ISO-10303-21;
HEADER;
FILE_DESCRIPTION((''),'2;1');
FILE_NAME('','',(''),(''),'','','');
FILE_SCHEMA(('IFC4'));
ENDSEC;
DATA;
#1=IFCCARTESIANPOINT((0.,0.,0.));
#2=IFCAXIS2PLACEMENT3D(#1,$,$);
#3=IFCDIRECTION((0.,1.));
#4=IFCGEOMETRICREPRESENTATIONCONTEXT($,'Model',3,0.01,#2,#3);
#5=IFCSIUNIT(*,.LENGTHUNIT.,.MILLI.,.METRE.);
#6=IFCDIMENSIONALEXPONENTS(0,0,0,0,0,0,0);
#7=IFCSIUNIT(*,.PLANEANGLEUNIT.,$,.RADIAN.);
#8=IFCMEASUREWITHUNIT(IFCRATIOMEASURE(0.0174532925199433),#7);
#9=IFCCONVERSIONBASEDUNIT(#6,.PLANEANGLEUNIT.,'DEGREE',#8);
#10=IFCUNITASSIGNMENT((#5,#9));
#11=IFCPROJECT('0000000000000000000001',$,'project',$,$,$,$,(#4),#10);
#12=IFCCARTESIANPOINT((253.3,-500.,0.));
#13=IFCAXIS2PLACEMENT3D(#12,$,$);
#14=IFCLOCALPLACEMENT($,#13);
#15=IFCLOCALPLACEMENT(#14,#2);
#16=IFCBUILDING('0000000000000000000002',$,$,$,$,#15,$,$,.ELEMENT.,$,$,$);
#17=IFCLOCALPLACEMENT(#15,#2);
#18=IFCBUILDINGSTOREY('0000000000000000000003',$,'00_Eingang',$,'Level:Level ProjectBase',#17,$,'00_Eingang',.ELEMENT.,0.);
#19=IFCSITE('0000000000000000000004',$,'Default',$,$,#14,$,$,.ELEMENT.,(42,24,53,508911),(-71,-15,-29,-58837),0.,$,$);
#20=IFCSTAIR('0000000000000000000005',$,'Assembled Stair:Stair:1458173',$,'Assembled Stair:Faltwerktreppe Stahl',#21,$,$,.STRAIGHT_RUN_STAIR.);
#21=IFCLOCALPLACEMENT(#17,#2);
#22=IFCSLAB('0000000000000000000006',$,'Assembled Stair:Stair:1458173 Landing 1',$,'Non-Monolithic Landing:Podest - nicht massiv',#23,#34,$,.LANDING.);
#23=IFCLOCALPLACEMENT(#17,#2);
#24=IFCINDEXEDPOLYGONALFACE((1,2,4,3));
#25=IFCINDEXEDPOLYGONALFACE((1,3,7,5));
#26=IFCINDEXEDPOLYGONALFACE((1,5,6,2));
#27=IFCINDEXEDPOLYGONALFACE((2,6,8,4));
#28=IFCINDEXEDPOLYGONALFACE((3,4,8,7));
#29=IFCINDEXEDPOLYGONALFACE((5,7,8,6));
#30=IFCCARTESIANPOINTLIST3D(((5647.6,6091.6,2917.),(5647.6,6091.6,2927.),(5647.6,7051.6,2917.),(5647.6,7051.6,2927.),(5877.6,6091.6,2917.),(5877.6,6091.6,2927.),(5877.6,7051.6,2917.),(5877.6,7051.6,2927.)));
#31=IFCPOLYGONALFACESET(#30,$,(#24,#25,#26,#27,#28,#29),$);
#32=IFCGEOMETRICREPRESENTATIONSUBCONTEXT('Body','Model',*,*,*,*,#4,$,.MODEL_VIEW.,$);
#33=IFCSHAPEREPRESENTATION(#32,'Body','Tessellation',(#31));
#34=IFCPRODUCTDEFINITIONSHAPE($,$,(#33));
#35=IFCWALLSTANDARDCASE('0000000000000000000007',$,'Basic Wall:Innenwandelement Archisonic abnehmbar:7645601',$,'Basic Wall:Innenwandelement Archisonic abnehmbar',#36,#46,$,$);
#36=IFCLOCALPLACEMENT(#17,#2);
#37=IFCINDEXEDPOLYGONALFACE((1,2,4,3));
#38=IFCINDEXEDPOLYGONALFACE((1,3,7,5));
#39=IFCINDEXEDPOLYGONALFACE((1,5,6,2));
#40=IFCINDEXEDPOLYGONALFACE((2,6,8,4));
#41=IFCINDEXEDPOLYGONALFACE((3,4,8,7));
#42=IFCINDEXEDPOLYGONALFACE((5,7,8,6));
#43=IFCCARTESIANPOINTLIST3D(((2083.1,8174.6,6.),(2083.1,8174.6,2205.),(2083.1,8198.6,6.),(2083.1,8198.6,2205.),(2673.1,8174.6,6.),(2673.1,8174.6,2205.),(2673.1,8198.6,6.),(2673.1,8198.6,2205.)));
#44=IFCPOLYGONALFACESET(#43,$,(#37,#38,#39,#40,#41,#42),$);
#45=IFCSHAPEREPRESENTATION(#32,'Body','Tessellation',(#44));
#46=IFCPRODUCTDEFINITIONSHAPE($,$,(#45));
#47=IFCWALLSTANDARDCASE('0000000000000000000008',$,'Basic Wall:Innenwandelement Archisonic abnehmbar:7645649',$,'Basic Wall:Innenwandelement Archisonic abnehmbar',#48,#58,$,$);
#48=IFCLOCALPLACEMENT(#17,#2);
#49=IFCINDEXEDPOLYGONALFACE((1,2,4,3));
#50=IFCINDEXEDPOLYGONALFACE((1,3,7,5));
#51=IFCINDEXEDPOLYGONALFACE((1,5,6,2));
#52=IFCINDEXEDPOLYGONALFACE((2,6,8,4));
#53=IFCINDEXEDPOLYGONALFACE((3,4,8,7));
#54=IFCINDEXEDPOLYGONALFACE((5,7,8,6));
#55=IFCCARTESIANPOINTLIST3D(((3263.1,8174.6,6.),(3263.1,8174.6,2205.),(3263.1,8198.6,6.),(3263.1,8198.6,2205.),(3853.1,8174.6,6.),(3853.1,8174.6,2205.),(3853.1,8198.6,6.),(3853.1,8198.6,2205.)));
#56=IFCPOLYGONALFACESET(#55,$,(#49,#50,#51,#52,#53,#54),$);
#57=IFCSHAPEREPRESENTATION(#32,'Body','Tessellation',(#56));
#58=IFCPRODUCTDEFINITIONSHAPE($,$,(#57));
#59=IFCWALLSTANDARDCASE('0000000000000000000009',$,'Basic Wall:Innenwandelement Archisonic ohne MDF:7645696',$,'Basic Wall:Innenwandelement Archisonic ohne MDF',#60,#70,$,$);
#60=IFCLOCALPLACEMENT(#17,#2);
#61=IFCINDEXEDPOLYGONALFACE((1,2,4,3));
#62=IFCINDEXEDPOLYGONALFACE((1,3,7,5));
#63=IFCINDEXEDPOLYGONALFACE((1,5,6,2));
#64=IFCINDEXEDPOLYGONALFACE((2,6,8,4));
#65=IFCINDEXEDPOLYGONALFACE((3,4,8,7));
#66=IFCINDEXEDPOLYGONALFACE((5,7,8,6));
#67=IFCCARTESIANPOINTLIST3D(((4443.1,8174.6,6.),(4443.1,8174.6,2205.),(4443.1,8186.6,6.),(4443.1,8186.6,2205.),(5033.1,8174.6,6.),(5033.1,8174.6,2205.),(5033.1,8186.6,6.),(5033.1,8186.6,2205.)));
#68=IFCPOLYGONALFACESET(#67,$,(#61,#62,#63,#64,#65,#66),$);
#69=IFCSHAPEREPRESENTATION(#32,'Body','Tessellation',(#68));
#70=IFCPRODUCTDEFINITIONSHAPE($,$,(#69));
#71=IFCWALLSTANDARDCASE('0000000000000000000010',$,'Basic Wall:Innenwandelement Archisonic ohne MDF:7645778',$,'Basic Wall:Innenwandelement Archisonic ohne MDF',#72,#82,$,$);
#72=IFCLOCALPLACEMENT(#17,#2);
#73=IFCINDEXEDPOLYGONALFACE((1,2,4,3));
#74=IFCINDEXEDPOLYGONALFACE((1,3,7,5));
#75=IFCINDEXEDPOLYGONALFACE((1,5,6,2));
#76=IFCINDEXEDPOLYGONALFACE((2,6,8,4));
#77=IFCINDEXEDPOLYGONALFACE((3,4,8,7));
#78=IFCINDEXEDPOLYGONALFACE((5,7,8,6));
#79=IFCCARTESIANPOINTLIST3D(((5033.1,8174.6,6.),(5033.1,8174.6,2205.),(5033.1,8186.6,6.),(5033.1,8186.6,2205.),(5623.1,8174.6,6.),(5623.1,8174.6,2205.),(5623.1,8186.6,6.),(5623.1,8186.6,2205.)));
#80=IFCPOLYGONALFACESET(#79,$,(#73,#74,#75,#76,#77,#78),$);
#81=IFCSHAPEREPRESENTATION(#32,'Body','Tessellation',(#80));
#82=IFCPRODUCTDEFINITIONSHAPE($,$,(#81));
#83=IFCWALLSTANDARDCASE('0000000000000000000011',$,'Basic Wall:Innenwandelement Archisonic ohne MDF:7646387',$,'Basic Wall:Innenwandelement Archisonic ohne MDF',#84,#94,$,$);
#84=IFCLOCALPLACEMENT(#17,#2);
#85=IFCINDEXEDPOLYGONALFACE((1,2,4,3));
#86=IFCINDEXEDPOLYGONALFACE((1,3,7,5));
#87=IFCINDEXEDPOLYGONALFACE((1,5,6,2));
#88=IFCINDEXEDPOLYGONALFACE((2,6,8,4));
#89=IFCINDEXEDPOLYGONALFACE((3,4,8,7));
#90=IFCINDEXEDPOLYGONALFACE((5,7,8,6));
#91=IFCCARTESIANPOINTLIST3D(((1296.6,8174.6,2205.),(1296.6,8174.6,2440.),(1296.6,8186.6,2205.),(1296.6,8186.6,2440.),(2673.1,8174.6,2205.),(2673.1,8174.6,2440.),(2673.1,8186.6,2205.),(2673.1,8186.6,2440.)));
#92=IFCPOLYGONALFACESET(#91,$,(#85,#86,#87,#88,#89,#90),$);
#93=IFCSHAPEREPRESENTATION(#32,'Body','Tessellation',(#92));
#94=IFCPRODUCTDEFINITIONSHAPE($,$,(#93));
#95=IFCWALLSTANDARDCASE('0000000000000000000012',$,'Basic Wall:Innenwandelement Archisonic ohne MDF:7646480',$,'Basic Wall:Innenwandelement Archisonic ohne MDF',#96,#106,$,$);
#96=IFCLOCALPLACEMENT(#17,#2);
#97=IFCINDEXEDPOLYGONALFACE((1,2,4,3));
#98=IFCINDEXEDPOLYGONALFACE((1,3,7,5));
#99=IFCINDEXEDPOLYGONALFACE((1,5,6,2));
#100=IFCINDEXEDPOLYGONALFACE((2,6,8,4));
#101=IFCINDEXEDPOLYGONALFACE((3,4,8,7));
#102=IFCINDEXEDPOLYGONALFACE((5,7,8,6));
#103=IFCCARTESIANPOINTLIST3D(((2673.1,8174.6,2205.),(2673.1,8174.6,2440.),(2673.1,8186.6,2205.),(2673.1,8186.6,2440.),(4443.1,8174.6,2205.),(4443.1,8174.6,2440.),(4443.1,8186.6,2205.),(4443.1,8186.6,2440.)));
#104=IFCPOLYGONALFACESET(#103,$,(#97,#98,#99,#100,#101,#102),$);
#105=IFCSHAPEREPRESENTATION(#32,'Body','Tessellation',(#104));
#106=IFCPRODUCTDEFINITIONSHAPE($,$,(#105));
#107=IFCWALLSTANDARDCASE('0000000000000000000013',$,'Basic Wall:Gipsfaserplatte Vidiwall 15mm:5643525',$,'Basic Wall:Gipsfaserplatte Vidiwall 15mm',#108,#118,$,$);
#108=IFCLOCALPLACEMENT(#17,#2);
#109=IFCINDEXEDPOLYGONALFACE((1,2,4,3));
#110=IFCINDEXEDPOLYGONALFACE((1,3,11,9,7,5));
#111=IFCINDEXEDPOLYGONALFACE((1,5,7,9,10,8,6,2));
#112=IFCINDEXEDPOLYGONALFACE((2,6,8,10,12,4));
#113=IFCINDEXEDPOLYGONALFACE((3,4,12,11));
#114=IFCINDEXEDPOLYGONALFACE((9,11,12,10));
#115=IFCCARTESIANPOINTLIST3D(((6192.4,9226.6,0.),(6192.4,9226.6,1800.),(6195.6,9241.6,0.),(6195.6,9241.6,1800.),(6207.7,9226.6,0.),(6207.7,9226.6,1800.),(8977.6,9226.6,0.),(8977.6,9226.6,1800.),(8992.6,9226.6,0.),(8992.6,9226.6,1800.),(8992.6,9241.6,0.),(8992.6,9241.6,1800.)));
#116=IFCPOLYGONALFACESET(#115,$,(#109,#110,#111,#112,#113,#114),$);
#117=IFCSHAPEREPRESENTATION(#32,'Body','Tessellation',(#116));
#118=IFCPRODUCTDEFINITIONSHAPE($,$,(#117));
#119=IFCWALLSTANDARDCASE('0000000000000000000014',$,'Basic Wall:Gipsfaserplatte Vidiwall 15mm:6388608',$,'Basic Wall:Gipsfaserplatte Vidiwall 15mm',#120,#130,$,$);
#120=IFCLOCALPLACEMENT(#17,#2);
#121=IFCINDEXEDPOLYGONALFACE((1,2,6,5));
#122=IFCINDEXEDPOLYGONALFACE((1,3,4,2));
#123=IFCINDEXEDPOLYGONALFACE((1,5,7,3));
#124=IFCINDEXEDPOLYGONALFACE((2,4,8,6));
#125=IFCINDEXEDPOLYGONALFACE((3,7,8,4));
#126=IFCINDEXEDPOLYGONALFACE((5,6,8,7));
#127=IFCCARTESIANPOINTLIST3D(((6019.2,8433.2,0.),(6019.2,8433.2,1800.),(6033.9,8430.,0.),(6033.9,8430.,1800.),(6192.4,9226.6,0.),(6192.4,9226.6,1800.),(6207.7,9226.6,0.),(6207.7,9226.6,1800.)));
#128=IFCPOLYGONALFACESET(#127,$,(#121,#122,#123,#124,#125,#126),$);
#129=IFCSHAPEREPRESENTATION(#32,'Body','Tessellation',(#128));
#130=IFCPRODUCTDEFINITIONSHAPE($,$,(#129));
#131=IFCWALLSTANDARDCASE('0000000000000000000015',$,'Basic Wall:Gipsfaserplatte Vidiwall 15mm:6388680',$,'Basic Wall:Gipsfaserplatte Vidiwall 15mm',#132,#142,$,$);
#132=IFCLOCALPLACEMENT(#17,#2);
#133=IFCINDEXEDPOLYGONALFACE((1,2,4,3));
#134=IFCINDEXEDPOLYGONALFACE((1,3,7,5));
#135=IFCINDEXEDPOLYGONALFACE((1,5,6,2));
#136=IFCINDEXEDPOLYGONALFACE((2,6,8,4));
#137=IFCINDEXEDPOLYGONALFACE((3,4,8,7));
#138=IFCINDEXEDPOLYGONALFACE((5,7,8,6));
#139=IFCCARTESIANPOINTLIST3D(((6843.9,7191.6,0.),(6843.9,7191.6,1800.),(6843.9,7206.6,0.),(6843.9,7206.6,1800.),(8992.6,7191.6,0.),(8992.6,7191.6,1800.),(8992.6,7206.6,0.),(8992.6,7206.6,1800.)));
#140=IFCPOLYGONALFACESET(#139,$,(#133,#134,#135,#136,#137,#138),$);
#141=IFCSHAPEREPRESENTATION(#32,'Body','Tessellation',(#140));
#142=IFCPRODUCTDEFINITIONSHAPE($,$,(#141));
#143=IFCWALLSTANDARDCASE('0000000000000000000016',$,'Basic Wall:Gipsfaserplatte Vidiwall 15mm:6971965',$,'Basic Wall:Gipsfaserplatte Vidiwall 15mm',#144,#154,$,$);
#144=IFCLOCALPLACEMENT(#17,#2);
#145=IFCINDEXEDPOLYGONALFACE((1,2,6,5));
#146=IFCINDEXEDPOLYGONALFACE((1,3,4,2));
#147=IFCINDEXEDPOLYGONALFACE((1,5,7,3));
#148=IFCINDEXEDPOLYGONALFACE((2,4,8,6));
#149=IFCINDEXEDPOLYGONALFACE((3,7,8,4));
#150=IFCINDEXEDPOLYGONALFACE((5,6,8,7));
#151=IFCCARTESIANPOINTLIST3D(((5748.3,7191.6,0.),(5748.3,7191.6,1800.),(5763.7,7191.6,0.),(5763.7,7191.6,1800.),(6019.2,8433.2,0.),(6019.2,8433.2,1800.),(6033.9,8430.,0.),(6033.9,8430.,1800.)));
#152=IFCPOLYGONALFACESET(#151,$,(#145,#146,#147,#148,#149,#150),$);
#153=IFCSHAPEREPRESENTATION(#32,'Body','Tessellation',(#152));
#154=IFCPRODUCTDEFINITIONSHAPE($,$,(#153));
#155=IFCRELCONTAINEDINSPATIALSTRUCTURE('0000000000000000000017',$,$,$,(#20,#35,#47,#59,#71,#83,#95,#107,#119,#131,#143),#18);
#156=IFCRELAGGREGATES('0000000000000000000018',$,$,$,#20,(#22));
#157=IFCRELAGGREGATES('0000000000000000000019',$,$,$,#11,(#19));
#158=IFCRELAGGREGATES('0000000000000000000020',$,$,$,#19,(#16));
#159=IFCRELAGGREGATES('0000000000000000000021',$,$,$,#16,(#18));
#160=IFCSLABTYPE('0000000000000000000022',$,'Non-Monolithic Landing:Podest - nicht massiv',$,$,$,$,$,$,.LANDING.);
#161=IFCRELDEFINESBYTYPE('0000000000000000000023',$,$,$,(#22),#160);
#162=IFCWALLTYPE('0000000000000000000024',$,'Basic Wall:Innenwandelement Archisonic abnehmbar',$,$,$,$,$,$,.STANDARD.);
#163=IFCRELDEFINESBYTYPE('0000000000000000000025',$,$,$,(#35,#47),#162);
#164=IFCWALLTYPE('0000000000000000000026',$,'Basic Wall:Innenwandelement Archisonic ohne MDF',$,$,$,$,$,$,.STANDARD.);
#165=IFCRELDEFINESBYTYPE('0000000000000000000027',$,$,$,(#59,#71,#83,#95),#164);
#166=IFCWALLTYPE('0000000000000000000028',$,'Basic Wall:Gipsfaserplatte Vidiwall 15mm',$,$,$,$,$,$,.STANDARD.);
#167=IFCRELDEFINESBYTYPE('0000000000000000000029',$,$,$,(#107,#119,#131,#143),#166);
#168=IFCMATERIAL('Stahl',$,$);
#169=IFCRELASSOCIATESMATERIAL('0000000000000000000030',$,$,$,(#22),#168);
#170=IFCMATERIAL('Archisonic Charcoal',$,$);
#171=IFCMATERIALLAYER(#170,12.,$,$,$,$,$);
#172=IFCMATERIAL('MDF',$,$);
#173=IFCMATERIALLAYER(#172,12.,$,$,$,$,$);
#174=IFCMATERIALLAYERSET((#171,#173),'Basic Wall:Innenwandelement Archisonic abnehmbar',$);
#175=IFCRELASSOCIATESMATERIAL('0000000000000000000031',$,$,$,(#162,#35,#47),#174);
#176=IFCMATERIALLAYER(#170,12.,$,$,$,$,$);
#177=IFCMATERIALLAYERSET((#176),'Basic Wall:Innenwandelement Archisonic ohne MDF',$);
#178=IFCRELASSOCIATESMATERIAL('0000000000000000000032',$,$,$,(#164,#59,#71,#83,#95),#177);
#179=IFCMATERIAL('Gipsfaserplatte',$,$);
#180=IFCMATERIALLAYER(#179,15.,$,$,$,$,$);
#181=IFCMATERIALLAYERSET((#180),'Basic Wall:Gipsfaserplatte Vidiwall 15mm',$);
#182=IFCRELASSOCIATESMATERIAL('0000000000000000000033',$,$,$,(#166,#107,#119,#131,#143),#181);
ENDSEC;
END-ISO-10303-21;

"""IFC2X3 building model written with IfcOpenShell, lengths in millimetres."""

from ifc_helpers import new_model, entity, si_unit, converted_unit, direction, frame, frame_2d, origin, place, context, subcontext, project, spatial, polyline, rectangle, outline, extrude, clip, bounded_halfspace, material, layer, layer_set, layer_usage, type_object, element, aggregate, save


model = new_model("IFC2X3")

# Units and contexts
model_context = context("Model", 3, precision=0.01, world=origin(), true_north=direction((0.0, 1.0)))
body_context = subcontext(model_context, "Body", "Model", "MODEL_VIEW")
ifc_project = project(units=[si_unit("LENGTHUNIT", "METRE", prefix="MILLI"), converted_unit("PLANEANGLEUNIT", "DEGREE", entity("IfcRatioMeasure", 0.0174532925199433), si_unit("PLANEANGLEUNIT", "RADIAN"), dimensions=[0, 0, 0, 0, 0, 0, 0])], contexts=[model_context])

# Site, building, storey
site_placement = place(None, frame((253.3, -500.0, 0.0)))
site = spatial("IfcSite", under=ifc_project, at=site_placement, Name="Default", CompositionType="ELEMENT", RefLatitude=(42, 24, 53, 508911), RefLongitude=(-71, -15, -29, -58837), RefElevation=0.0)
building_placement = place(site_placement, origin())
building = spatial("IfcBuilding", under=site, at=building_placement, CompositionType="ELEMENT")
storey_placement = place(building_placement, origin())
storey = spatial("IfcBuildingStorey", under=building, at=storey_placement, Name="00_Eingang", ObjectType="Level:Level ProjectBase", LongName="00_Eingang", CompositionType="ELEMENT", Elevation=0.0)

# Stair, slab
stair_placement = place(storey_placement, origin())
stair = element("IfcStair", 1, at=stair_placement, inside=storey, Name="Assembled Stair:Stair:1458173", ObjectType="Assembled Stair:Faltwerktreppe Stahl", ShapeType="STRAIGHT_RUN_STAIR")
ifc_material_1 = material(Name="Stahl")
slab_type = type_object("IfcSlabType", Name="Non-Monolithic Landing:Podest - nicht massiv", PredefinedType="LANDING")
slab_placement = place(stair_placement, frame((5647.6, 6091.6, 0.0)))
slab = element("IfcSlab", 2, at=slab_placement, type_object=slab_type, material=ifc_material_1, Name="Assembled Stair:Stair:1458173 Landing 1", ObjectType="Non-Monolithic Landing:Podest - nicht massiv", PredefinedType="LANDING", context=body_context, shape_type="SweptSolid", body=[
    extrude(rectangle(XDim=960.0, YDim=230.0, at=frame_2d((0.0, 0.0), x_axis=(1.0, 0.0))), frame((115.0, 480.0, 2917.0), z_axis=(0.0, 0.0, 1.0), x_axis=(0.0, 1.0, 0.0)), (0.0, 0.0, 1.0), 10.0),
])

# Walls
ifc_material_2 = material(Name="Archisonic Charcoal")
ifc_layer_1 = layer(ifc_material_2, 12.0)
ifc_material_3 = material(Name="MDF")
ifc_layer_2 = layer(ifc_material_3, 12.0)
ifc_layer_set_1 = layer_set([ifc_layer_1, ifc_layer_2], Name="Basic Wall:Innenwandelement Archisonic abnehmbar")
ifc_layer_usage_1 = layer_usage(ifc_layer_set_1, "AXIS2", "NEGATIVE", 12.0)
wall_type_1 = type_object("IfcWallType", Name="Basic Wall:Innenwandelement Archisonic abnehmbar", PredefinedType="STANDARD", material=ifc_layer_set_1)
wall_1_placement = place(storey_placement, frame((2673.1, 8186.6, 6.0), z_axis=(0.0, 0.0, 1.0), x_axis=(-1.0, 0.0, 0.0)))
element("IfcWallStandardCase", 3, at=wall_1_placement, inside=storey, type_object=wall_type_1, material=ifc_layer_usage_1, Name="Basic Wall:Innenwandelement Archisonic abnehmbar:7645601", ObjectType="Basic Wall:Innenwandelement Archisonic abnehmbar", context=body_context, shape_type="SweptSolid", body=[
    extrude(rectangle(XDim=590.0, YDim=24.0, at=frame_2d((295.0, 0.0), x_axis=(-1.0, 0.0))), origin(), (0.0, 0.0, 1.0), 2199.0),
])
ifc_layer_usage_2 = layer_usage(ifc_layer_set_1, "AXIS2", "NEGATIVE", 12.0)
wall_2_placement = place(storey_placement, frame((3853.1, 8186.6, 6.0), z_axis=(0.0, 0.0, 1.0), x_axis=(-1.0, 0.0, 0.0)))
element("IfcWallStandardCase", 4, at=wall_2_placement, inside=storey, type_object=wall_type_1, material=ifc_layer_usage_2, Name="Basic Wall:Innenwandelement Archisonic abnehmbar:7645649", ObjectType="Basic Wall:Innenwandelement Archisonic abnehmbar", context=body_context, shape_type="SweptSolid", body=[
    extrude(rectangle(XDim=590.0, YDim=24.0, at=frame_2d((295.0, 0.0), x_axis=(-1.0, 0.0))), origin(), (0.0, 0.0, 1.0), 2199.0),
])

# Walls
ifc_layer_3 = layer(ifc_material_2, 12.0)
ifc_layer_set_2 = layer_set([ifc_layer_3], Name="Basic Wall:Innenwandelement Archisonic ohne MDF")
ifc_layer_usage_3 = layer_usage(ifc_layer_set_2, "AXIS2", "NEGATIVE", 6.0)
wall_type_2 = type_object("IfcWallType", Name="Basic Wall:Innenwandelement Archisonic ohne MDF", PredefinedType="STANDARD", material=ifc_layer_set_2)
wall_3_placement = place(storey_placement, frame((5033.1, 8180.6, 6.0), z_axis=(0.0, 0.0, 1.0), x_axis=(-1.0, 0.0, 0.0)))
element("IfcWallStandardCase", 5, at=wall_3_placement, inside=storey, type_object=wall_type_2, material=ifc_layer_usage_3, Name="Basic Wall:Innenwandelement Archisonic ohne MDF:7645696", ObjectType="Basic Wall:Innenwandelement Archisonic ohne MDF", context=body_context, shape_type="SweptSolid", body=[
    extrude(rectangle(XDim=590.0, YDim=12.0, at=frame_2d((295.0, 0.0), x_axis=(-1.0, 0.0))), origin(), (0.0, 0.0, 1.0), 2199.0),
])
ifc_layer_usage_4 = layer_usage(ifc_layer_set_2, "AXIS2", "NEGATIVE", 6.0)
wall_4_placement = place(storey_placement, frame((5623.1, 8180.6, 6.0), z_axis=(0.0, 0.0, 1.0), x_axis=(-1.0, 0.0, 0.0)))
element("IfcWallStandardCase", 6, at=wall_4_placement, inside=storey, type_object=wall_type_2, material=ifc_layer_usage_4, Name="Basic Wall:Innenwandelement Archisonic ohne MDF:7645778", ObjectType="Basic Wall:Innenwandelement Archisonic ohne MDF", context=body_context, shape_type="SweptSolid", body=[
    extrude(rectangle(XDim=590.0, YDim=12.0, at=frame_2d((295.0, 0.0), x_axis=(-1.0, 0.0))), origin(), (0.0, 0.0, 1.0), 2199.0),
])
ifc_layer_usage_5 = layer_usage(ifc_layer_set_2, "AXIS2", "NEGATIVE", 6.0)
wall_5_placement = place(storey_placement, frame((2673.1, 8180.6, 2205.0), z_axis=(0.0, 0.0, 1.0), x_axis=(-1.0, 0.0, 0.0)))
element("IfcWallStandardCase", 7, at=wall_5_placement, inside=storey, type_object=wall_type_2, material=ifc_layer_usage_5, Name="Basic Wall:Innenwandelement Archisonic ohne MDF:7646387", ObjectType="Basic Wall:Innenwandelement Archisonic ohne MDF", context=body_context, shape_type="SweptSolid", body=[
    extrude(rectangle(XDim=1376.4, YDim=12.0, at=frame_2d((688.2, 0.0), x_axis=(-1.0, 0.0))), origin(), (0.0, 0.0, 1.0), 235.0),
])
ifc_layer_usage_6 = layer_usage(ifc_layer_set_2, "AXIS2", "POSITIVE", -6.0)
wall_6_placement = place(storey_placement, frame((2673.1, 8180.6, 2205.0)))
element("IfcWallStandardCase", 8, at=wall_6_placement, inside=storey, type_object=wall_type_2, material=ifc_layer_usage_6, Name="Basic Wall:Innenwandelement Archisonic ohne MDF:7646480", ObjectType="Basic Wall:Innenwandelement Archisonic ohne MDF", context=body_context, shape_type="SweptSolid", body=[
    extrude(rectangle(XDim=1770.0, YDim=12.0, at=frame_2d((885.0, 0.0), x_axis=(-1.0, 0.0))), origin(), (0.0, 0.0, 1.0), 235.0),
])
ifc_material_4 = material(Name="Gipsfaserplatte")
ifc_layer_4 = layer(ifc_material_4, 15.0)
ifc_layer_set_3 = layer_set([ifc_layer_4], Name="Basic Wall:Gipsfaserplatte Vidiwall 15mm")
ifc_layer_usage_7 = layer_usage(ifc_layer_set_3, "AXIS2", "NEGATIVE", 7.5)
wall_type_3 = type_object("IfcWallType", Name="Basic Wall:Gipsfaserplatte Vidiwall 15mm", PredefinedType="STANDARD", material=ifc_layer_set_3)
wall_7_placement = place(storey_placement, frame((6192.4, 9234.1, 0.0)))
element("IfcWallStandardCase", 9, at=wall_7_placement, inside=storey, type_object=wall_type_3, material=ifc_layer_usage_7, Name="Basic Wall:Gipsfaserplatte Vidiwall 15mm:5643525", ObjectType="Basic Wall:Gipsfaserplatte Vidiwall 15mm", context=body_context, shape_type="SweptSolid", body=[
    extrude(outline(polyline([(2800.3, -7.5), (2800.3, 7.5), (3.3, 7.5), (0.0, -7.5), (15.4, -7.5), (2785.3, -7.5), (2800.3, -7.5)])), origin(), (0.0, 0.0, 1.0), 1800.0),
])
ifc_layer_usage_8 = layer_usage(ifc_layer_set_3, "AXIS2", "NEGATIVE", 7.5)
wall_8_placement = place(storey_placement, frame((6200.4, 9228.2, 0.0), z_axis=(0.0, 0.0, 1.0), x_axis=(-0.213201, -0.977008, 0.0)))
element("IfcWallStandardCase", 10, at=wall_8_placement, inside=storey, type_object=wall_type_3, material=ifc_layer_usage_8, Name="Basic Wall:Gipsfaserplatte Vidiwall 15mm:6388608", ObjectType="Basic Wall:Gipsfaserplatte Vidiwall 15mm", context=body_context, shape_type="Clipping", body=[
    clip(extrude(rectangle(XDim=815.4, YDim=15.0, at=frame_2d((407.7, 0.0), x_axis=(-1.0, 0.0))), origin(), (0.0, 0.0, 1.0), 1800.0), bounded_halfspace(frame((3.3, -7.5, 0.0), z_axis=(0.977008, 0.213201, 0.0), x_axis=(-0.213201, 0.977008, 0.0)), True, frame((3.3, -7.5, 0.0), z_axis=(0.977008, 0.213201, 0.0), x_axis=(-0.213201, 0.977008, 0.0)), polyline([(0.0, 0.0), (15.4, 0.0), (15.4, 1800.0), (0.0, 1800.0), (0.0, 0.0)]))),
])
ifc_layer_usage_9 = layer_usage(ifc_layer_set_3, "AXIS2", "NEGATIVE", 7.5)
wall_9_placement = place(storey_placement, frame((6843.9, 7199.1, 0.0)))
element("IfcWallStandardCase", 11, at=wall_9_placement, inside=storey, type_object=wall_type_3, material=ifc_layer_usage_9, Name="Basic Wall:Gipsfaserplatte Vidiwall 15mm:6388680", ObjectType="Basic Wall:Gipsfaserplatte Vidiwall 15mm", context=body_context, shape_type="SweptSolid", body=[
    extrude(rectangle(XDim=2148.8, YDim=15.0, at=frame_2d((1074.4, 0.0), x_axis=(-1.0, 0.0))), origin(), (0.0, 0.0, 1.0), 1800.0),
])
ifc_layer_usage_10 = layer_usage(ifc_layer_set_3, "AXIS2", "NEGATIVE", 7.5)
wall_10_placement = place(storey_placement, frame((6026.6, 8431.6, 0.0), z_axis=(0.0, 0.0, 1.0), x_axis=(-0.213201, -0.977008, 0.0)))
element("IfcWallStandardCase", 12, at=wall_10_placement, inside=storey, type_object=wall_type_3, material=ifc_layer_usage_10, Name="Basic Wall:Gipsfaserplatte Vidiwall 15mm:6971965", ObjectType="Basic Wall:Gipsfaserplatte Vidiwall 15mm", context=body_context, shape_type="SweptSolid", body=[
    extrude(outline(polyline([(1270.8, -7.5), (1267.5, 7.5), (0.0, 7.5), (0.0, -7.5), (1270.8, -7.5)])), origin(), (0.0, 0.0, 1.0), 1800.0),
])

aggregate(stair, [slab])

save(model, "model.ifc")
